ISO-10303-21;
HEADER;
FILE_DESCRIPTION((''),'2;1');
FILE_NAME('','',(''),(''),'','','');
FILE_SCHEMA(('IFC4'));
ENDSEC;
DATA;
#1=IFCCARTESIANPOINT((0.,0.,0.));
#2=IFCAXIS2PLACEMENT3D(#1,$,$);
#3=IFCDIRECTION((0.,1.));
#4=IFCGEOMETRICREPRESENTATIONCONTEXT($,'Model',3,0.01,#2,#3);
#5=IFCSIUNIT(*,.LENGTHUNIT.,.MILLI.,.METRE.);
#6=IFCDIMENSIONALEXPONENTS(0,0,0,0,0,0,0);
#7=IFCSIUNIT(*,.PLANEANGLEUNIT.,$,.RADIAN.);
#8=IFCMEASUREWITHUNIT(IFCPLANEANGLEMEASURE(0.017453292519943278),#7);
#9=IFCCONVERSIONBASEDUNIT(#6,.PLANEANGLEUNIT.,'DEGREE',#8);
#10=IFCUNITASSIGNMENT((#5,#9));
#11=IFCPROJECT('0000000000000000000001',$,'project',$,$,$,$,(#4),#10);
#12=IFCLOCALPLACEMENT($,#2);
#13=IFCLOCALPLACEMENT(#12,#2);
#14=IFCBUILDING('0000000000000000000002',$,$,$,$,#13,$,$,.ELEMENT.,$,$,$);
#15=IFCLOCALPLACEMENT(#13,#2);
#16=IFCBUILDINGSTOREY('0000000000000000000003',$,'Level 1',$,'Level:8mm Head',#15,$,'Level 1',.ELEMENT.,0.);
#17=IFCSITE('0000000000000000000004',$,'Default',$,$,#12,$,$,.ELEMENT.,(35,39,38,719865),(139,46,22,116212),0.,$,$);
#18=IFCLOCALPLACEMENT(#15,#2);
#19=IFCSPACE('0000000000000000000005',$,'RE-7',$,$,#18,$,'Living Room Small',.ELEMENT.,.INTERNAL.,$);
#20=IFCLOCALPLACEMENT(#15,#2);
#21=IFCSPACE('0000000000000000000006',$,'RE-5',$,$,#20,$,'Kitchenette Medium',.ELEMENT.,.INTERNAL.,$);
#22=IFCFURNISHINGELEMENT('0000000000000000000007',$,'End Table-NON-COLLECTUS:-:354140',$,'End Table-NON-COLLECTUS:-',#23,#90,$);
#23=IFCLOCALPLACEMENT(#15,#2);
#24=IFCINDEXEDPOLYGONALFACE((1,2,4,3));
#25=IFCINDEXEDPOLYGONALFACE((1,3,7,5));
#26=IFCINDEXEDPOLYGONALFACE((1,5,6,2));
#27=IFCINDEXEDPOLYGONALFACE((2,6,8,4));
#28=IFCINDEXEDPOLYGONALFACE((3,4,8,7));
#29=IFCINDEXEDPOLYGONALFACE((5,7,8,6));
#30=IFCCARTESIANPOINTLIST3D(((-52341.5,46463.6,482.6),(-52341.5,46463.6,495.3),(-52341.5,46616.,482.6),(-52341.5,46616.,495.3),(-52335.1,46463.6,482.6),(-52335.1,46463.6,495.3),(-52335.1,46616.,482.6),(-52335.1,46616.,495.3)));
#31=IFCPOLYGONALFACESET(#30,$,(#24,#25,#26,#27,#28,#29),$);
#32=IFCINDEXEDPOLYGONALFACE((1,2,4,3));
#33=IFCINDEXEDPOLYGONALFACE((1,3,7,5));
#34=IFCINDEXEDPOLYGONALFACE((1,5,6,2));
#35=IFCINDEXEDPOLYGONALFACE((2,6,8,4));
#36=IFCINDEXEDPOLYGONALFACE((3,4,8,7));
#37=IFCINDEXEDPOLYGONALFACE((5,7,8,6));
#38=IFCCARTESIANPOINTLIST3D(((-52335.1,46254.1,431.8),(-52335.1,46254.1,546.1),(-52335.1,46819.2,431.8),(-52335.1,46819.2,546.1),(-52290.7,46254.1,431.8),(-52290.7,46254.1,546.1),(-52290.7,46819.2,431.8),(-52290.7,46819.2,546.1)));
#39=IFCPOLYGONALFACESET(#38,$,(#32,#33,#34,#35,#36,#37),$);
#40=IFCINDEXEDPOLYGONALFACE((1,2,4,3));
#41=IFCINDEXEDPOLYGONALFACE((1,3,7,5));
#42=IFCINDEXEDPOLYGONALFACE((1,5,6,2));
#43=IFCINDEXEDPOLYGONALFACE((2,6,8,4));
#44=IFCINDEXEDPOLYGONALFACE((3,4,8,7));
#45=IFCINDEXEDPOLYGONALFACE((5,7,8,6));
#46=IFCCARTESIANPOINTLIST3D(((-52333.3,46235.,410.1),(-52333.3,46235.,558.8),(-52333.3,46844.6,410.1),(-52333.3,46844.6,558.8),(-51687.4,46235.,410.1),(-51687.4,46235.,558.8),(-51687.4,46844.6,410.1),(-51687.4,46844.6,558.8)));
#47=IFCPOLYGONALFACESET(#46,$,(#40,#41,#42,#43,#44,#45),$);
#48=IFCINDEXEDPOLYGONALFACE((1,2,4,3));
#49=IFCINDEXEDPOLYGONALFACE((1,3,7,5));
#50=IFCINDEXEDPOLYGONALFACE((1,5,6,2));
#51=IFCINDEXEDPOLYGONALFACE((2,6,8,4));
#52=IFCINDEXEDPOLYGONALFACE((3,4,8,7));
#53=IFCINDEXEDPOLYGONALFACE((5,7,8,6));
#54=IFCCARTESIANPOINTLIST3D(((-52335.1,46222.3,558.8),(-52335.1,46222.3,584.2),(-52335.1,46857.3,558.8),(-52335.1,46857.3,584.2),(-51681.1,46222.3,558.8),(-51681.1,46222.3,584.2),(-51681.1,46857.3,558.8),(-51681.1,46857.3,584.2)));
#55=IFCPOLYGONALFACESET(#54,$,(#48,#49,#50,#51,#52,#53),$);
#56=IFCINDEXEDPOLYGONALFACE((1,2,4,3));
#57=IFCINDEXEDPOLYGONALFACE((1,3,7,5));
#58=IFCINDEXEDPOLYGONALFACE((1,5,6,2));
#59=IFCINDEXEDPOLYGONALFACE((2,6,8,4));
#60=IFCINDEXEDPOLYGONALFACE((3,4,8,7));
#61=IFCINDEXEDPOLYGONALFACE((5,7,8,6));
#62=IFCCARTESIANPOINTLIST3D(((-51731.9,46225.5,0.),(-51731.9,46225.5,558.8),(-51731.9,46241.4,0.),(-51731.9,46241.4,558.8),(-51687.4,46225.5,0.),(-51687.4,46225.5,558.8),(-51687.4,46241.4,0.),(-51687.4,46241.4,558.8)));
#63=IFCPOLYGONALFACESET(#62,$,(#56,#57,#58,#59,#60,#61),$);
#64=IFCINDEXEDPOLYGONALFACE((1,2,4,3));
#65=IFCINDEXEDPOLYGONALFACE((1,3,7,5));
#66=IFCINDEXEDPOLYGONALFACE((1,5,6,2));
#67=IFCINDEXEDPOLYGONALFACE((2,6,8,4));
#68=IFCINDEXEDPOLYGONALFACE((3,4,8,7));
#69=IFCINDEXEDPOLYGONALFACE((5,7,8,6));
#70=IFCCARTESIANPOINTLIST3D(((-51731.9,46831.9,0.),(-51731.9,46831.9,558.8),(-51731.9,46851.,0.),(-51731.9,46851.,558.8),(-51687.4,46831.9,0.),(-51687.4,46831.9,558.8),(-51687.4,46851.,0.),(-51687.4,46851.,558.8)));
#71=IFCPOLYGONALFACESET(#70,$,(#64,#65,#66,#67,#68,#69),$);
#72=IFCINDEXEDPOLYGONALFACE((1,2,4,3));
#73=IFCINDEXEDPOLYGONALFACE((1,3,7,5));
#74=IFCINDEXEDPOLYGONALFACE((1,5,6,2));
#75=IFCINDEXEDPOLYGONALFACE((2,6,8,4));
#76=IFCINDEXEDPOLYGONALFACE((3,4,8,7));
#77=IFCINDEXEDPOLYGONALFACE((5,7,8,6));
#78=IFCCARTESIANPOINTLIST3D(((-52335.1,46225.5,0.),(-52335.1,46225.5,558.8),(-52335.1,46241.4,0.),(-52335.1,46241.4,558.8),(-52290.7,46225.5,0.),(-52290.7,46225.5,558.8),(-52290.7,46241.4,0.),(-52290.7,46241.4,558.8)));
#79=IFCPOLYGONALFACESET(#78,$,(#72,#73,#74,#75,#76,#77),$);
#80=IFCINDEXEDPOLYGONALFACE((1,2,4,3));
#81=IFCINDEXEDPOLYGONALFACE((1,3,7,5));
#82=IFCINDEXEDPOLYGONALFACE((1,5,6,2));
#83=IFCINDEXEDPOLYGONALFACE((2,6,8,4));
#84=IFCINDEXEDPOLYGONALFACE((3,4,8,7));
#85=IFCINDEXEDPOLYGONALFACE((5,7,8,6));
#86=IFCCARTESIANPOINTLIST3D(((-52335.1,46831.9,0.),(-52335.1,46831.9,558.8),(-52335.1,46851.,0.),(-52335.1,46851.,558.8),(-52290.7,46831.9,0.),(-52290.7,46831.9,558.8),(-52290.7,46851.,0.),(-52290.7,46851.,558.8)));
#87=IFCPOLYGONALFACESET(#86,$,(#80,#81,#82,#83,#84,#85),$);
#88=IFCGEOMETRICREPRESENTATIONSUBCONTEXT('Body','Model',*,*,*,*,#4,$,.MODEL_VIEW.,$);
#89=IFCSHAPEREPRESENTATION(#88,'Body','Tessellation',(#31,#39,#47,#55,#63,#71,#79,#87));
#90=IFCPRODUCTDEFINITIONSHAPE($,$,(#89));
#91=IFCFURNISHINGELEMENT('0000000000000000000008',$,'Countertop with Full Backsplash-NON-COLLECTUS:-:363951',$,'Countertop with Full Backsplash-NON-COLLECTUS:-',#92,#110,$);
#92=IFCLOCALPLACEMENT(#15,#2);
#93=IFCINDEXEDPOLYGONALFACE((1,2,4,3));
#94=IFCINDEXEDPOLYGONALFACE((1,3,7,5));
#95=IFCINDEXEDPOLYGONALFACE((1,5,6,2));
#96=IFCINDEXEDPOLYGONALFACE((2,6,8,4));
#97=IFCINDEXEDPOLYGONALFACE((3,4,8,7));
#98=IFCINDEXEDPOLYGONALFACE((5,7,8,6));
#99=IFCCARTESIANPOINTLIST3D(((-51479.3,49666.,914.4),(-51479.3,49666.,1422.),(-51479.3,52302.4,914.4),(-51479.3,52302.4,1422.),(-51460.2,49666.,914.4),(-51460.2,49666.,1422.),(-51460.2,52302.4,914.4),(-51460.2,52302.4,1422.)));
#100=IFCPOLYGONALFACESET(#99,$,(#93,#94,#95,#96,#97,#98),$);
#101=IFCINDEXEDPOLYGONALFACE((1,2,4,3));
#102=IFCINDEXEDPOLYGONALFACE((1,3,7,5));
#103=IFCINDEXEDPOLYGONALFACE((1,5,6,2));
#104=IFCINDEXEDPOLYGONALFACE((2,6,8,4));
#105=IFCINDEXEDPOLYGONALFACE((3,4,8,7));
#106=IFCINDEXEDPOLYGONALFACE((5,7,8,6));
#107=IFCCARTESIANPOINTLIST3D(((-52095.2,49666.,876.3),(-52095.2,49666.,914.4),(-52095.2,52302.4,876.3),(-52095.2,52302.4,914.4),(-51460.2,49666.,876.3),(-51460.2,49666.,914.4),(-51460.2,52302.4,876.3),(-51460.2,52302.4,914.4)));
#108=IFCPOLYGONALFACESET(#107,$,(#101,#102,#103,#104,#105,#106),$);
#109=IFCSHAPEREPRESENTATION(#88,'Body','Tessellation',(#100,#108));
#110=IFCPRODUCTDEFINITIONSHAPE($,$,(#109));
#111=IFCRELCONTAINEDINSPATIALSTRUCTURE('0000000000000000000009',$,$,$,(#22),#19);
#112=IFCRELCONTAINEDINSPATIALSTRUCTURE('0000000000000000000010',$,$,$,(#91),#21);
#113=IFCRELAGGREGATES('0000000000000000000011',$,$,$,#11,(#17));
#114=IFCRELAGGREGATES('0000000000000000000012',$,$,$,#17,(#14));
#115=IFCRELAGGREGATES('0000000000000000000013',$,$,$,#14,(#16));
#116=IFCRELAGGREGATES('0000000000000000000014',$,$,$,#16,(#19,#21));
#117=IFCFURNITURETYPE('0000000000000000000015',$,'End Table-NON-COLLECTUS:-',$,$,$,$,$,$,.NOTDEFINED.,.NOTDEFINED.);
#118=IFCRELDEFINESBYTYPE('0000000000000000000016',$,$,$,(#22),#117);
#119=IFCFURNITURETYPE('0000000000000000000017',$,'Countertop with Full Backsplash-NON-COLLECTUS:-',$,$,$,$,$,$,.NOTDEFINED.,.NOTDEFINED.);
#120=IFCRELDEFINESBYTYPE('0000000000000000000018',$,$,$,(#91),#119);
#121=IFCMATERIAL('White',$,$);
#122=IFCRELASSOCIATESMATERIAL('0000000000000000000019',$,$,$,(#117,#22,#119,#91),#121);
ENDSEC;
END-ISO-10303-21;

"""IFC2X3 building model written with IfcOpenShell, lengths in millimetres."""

from ifc_helpers import new_model, entity, si_unit, converted_unit, direction, frame, frame_2d, origin, origin_2d_with_axis, place, context, subcontext, project, spatial, rectangle, extrude, source, transform, mapped, material, type_object, type_shapes, element, save


model = new_model("IFC2X3")

# Units and contexts
model_context = context("Model", 3, precision=0.01, world=origin(), true_north=direction((0.0, 1.0)))
body_context = subcontext(model_context, "Body", "Model", "MODEL_VIEW")
ifc_project = project(units=[si_unit("LENGTHUNIT", "METRE", prefix="MILLI"), converted_unit("PLANEANGLEUNIT", "DEGREE", entity("IfcPlaneAngleMeasure", 0.017453292519943278), si_unit("PLANEANGLEUNIT", "RADIAN"), dimensions=[0, 0, 0, 0, 0, 0, 0])], contexts=[model_context])

# Site, building, storey
site_placement = place(None, origin())
site = spatial("IfcSite", under=ifc_project, at=site_placement, Name="Default", CompositionType="ELEMENT", RefLatitude=(35, 39, 38, 719865), RefLongitude=(139, 46, 22, 116212), RefElevation=0.0)
building_placement = place(site_placement, origin())
building = spatial("IfcBuilding", under=site, at=building_placement, CompositionType="ELEMENT")
storey_placement = place(building_placement, origin())
storey = spatial("IfcBuildingStorey", under=building, at=storey_placement, Name="Level 1", ObjectType="Level:8mm Head", LongName="Level 1", CompositionType="ELEMENT", Elevation=0.0)

# Shared definitions
space_1_placement = place(storey_placement, origin())
space_1 = spatial("IfcSpace", under=storey, at=space_1_placement, Name="RE-7", LongName="Living Room Small", CompositionType="ELEMENT", InteriorOrExteriorSpace="INTERNAL")

# Furnishing element
ifc_material_1 = material(Name="White")
furniture_type_1 = type_object("IfcFurnitureType", Name="End Table-NON-COLLECTUS:-", AssemblyPlace="NOTDEFINED", material=ifc_material_1)
shared_shape_1 = source(origin(), body_context, "Body", "SweptSolid", [
    extrude(rectangle(XDim=6.4, YDim=152.4, at=origin_2d_with_axis()), frame((0.0, -657.2, 482.6), z_axis=(0.0, 0.0, 1.0), x_axis=(0.0, 1.0, 0.0)), (0.0, 0.0, 1.0), 12.7),
    extrude(rectangle(XDim=44.4, YDim=565.2, at=origin_2d_with_axis()), frame((3.2, -631.8, 431.8), z_axis=(0.0, 0.0, 1.0), x_axis=(0.0, 1.0, 0.0)), (0.0, 0.0, 1.0), 114.3),
    extrude(rectangle(XDim=609.6, YDim=645.8, at=frame_2d((0.0, 0.0), x_axis=(1.0, 0.0))), frame((0.0, -329.3, 410.1), z_axis=(0.0, 0.0, 1.0), x_axis=(-1.0, 0.0, 0.0)), (0.0, 0.0, 1.0), 148.7),
    extrude(rectangle(XDim=635.0, YDim=654.0, at=frame_2d((0.0, 0.0), x_axis=(1.0, 0.0))), frame((0.0, -327.0, 558.8), z_axis=(0.0, 0.0, 1.0), x_axis=(-1.0, 0.0, 0.0)), (0.0, 0.0, 1.0), 25.4),
    extrude(rectangle(XDim=15.8, YDim=44.4, at=origin_2d_with_axis()), frame((306.4, -28.6, 0.0), z_axis=(0.0, 0.0, 1.0), x_axis=(-1.0, 0.0, 0.0)), (0.0, 0.0, 1.0), 558.8),
    extrude(rectangle(XDim=19.1, YDim=44.5, at=origin_2d_with_axis()), frame((-301.6, -28.6, 0.0), z_axis=(0.0, 0.0, 1.0), x_axis=(-1.0, 0.0, 0.0)), (0.0, 0.0, 1.0), 558.8),
    extrude(rectangle(XDim=15.8, YDim=44.4, at=origin_2d_with_axis()), frame((306.4, -631.8, 0.0), z_axis=(0.0, 0.0, 1.0), x_axis=(-1.0, 0.0, 0.0)), (0.0, 0.0, 1.0), 558.8),
    extrude(rectangle(XDim=19.1, YDim=44.4, at=frame_2d((0.0, 0.0), x_axis=(1.0, 0.0))), frame((-301.6, -631.8, 0.0), z_axis=(0.0, 0.0, 1.0), x_axis=(-1.0, 0.0, 0.0)), (0.0, 0.0, 1.0), 558.8),
])
type_shapes(furniture_type_1, [shared_shape_1])
furnishing_1_placement = place(space_1_placement, frame((-51681.1, 46539.8, 0.0), z_axis=(0.0, 0.0, 1.0), x_axis=(-0.000004, -1.0, 0.0)))
element("IfcFurnishingElement", 1, at=furnishing_1_placement, inside=space_1, type_object=furniture_type_1, material=ifc_material_1, Name="End Table-NON-COLLECTUS:-:354140", ObjectType="End Table-NON-COLLECTUS:-", context=body_context, shape_type="MappedRepresentation", body=[
    mapped(shared_shape_1, transform((0.0, 0.0, 0.0), scale=1.0)),
])

# Shared definitions
space_2_placement = place(storey_placement, origin())
space_2 = spatial("IfcSpace", under=storey, at=space_2_placement, Name="RE-5", LongName="Kitchenette Medium", CompositionType="ELEMENT", InteriorOrExteriorSpace="INTERNAL")

# Furnishing element
furniture_type_2 = type_object("IfcFurnitureType", Name="Countertop with Full Backsplash-NON-COLLECTUS:-", AssemblyPlace="NOTDEFINED", material=ifc_material_1)
shared_shape_2 = source(origin(), body_context, "Body", "SweptSolid", [
    extrude(rectangle(XDim=19.1, YDim=2636.4, at=frame_2d((0.0, 0.0), x_axis=(1.0, 0.0))), frame((117.7, -9.5, 38.1), z_axis=(0.0, 0.0, 1.0), x_axis=(0.0, -1.0, 0.0)), (0.0, 0.0, 1.0), 507.6),
    extrude(rectangle(XDim=2636.4, YDim=635.0, at=origin_2d_with_axis()), frame((117.7, -317.5, 0.0), z_axis=(0.0, 0.0, 1.0), x_axis=(-1.0, 0.0, 0.0)), (0.0, 0.0, 1.0), 38.1),
])
type_shapes(furniture_type_2, [shared_shape_2])
furnishing_2_placement = place(space_2_placement, frame((-51460.2, 51101.9, 876.3), z_axis=(0.0, 0.0, 1.0), x_axis=(0.000011, -1.0, 0.0)))
element("IfcFurnishingElement", 2, at=furnishing_2_placement, inside=space_2, type_object=furniture_type_2, material=ifc_material_1, Name="Countertop with Full Backsplash-NON-COLLECTUS:-:363951", ObjectType="Countertop with Full Backsplash-NON-COLLECTUS:-", context=body_context, shape_type="MappedRepresentation", body=[
    mapped(shared_shape_2, transform((0.0, 0.0, 0.0), scale=1.0)),
])

save(model, "model.ifc")
